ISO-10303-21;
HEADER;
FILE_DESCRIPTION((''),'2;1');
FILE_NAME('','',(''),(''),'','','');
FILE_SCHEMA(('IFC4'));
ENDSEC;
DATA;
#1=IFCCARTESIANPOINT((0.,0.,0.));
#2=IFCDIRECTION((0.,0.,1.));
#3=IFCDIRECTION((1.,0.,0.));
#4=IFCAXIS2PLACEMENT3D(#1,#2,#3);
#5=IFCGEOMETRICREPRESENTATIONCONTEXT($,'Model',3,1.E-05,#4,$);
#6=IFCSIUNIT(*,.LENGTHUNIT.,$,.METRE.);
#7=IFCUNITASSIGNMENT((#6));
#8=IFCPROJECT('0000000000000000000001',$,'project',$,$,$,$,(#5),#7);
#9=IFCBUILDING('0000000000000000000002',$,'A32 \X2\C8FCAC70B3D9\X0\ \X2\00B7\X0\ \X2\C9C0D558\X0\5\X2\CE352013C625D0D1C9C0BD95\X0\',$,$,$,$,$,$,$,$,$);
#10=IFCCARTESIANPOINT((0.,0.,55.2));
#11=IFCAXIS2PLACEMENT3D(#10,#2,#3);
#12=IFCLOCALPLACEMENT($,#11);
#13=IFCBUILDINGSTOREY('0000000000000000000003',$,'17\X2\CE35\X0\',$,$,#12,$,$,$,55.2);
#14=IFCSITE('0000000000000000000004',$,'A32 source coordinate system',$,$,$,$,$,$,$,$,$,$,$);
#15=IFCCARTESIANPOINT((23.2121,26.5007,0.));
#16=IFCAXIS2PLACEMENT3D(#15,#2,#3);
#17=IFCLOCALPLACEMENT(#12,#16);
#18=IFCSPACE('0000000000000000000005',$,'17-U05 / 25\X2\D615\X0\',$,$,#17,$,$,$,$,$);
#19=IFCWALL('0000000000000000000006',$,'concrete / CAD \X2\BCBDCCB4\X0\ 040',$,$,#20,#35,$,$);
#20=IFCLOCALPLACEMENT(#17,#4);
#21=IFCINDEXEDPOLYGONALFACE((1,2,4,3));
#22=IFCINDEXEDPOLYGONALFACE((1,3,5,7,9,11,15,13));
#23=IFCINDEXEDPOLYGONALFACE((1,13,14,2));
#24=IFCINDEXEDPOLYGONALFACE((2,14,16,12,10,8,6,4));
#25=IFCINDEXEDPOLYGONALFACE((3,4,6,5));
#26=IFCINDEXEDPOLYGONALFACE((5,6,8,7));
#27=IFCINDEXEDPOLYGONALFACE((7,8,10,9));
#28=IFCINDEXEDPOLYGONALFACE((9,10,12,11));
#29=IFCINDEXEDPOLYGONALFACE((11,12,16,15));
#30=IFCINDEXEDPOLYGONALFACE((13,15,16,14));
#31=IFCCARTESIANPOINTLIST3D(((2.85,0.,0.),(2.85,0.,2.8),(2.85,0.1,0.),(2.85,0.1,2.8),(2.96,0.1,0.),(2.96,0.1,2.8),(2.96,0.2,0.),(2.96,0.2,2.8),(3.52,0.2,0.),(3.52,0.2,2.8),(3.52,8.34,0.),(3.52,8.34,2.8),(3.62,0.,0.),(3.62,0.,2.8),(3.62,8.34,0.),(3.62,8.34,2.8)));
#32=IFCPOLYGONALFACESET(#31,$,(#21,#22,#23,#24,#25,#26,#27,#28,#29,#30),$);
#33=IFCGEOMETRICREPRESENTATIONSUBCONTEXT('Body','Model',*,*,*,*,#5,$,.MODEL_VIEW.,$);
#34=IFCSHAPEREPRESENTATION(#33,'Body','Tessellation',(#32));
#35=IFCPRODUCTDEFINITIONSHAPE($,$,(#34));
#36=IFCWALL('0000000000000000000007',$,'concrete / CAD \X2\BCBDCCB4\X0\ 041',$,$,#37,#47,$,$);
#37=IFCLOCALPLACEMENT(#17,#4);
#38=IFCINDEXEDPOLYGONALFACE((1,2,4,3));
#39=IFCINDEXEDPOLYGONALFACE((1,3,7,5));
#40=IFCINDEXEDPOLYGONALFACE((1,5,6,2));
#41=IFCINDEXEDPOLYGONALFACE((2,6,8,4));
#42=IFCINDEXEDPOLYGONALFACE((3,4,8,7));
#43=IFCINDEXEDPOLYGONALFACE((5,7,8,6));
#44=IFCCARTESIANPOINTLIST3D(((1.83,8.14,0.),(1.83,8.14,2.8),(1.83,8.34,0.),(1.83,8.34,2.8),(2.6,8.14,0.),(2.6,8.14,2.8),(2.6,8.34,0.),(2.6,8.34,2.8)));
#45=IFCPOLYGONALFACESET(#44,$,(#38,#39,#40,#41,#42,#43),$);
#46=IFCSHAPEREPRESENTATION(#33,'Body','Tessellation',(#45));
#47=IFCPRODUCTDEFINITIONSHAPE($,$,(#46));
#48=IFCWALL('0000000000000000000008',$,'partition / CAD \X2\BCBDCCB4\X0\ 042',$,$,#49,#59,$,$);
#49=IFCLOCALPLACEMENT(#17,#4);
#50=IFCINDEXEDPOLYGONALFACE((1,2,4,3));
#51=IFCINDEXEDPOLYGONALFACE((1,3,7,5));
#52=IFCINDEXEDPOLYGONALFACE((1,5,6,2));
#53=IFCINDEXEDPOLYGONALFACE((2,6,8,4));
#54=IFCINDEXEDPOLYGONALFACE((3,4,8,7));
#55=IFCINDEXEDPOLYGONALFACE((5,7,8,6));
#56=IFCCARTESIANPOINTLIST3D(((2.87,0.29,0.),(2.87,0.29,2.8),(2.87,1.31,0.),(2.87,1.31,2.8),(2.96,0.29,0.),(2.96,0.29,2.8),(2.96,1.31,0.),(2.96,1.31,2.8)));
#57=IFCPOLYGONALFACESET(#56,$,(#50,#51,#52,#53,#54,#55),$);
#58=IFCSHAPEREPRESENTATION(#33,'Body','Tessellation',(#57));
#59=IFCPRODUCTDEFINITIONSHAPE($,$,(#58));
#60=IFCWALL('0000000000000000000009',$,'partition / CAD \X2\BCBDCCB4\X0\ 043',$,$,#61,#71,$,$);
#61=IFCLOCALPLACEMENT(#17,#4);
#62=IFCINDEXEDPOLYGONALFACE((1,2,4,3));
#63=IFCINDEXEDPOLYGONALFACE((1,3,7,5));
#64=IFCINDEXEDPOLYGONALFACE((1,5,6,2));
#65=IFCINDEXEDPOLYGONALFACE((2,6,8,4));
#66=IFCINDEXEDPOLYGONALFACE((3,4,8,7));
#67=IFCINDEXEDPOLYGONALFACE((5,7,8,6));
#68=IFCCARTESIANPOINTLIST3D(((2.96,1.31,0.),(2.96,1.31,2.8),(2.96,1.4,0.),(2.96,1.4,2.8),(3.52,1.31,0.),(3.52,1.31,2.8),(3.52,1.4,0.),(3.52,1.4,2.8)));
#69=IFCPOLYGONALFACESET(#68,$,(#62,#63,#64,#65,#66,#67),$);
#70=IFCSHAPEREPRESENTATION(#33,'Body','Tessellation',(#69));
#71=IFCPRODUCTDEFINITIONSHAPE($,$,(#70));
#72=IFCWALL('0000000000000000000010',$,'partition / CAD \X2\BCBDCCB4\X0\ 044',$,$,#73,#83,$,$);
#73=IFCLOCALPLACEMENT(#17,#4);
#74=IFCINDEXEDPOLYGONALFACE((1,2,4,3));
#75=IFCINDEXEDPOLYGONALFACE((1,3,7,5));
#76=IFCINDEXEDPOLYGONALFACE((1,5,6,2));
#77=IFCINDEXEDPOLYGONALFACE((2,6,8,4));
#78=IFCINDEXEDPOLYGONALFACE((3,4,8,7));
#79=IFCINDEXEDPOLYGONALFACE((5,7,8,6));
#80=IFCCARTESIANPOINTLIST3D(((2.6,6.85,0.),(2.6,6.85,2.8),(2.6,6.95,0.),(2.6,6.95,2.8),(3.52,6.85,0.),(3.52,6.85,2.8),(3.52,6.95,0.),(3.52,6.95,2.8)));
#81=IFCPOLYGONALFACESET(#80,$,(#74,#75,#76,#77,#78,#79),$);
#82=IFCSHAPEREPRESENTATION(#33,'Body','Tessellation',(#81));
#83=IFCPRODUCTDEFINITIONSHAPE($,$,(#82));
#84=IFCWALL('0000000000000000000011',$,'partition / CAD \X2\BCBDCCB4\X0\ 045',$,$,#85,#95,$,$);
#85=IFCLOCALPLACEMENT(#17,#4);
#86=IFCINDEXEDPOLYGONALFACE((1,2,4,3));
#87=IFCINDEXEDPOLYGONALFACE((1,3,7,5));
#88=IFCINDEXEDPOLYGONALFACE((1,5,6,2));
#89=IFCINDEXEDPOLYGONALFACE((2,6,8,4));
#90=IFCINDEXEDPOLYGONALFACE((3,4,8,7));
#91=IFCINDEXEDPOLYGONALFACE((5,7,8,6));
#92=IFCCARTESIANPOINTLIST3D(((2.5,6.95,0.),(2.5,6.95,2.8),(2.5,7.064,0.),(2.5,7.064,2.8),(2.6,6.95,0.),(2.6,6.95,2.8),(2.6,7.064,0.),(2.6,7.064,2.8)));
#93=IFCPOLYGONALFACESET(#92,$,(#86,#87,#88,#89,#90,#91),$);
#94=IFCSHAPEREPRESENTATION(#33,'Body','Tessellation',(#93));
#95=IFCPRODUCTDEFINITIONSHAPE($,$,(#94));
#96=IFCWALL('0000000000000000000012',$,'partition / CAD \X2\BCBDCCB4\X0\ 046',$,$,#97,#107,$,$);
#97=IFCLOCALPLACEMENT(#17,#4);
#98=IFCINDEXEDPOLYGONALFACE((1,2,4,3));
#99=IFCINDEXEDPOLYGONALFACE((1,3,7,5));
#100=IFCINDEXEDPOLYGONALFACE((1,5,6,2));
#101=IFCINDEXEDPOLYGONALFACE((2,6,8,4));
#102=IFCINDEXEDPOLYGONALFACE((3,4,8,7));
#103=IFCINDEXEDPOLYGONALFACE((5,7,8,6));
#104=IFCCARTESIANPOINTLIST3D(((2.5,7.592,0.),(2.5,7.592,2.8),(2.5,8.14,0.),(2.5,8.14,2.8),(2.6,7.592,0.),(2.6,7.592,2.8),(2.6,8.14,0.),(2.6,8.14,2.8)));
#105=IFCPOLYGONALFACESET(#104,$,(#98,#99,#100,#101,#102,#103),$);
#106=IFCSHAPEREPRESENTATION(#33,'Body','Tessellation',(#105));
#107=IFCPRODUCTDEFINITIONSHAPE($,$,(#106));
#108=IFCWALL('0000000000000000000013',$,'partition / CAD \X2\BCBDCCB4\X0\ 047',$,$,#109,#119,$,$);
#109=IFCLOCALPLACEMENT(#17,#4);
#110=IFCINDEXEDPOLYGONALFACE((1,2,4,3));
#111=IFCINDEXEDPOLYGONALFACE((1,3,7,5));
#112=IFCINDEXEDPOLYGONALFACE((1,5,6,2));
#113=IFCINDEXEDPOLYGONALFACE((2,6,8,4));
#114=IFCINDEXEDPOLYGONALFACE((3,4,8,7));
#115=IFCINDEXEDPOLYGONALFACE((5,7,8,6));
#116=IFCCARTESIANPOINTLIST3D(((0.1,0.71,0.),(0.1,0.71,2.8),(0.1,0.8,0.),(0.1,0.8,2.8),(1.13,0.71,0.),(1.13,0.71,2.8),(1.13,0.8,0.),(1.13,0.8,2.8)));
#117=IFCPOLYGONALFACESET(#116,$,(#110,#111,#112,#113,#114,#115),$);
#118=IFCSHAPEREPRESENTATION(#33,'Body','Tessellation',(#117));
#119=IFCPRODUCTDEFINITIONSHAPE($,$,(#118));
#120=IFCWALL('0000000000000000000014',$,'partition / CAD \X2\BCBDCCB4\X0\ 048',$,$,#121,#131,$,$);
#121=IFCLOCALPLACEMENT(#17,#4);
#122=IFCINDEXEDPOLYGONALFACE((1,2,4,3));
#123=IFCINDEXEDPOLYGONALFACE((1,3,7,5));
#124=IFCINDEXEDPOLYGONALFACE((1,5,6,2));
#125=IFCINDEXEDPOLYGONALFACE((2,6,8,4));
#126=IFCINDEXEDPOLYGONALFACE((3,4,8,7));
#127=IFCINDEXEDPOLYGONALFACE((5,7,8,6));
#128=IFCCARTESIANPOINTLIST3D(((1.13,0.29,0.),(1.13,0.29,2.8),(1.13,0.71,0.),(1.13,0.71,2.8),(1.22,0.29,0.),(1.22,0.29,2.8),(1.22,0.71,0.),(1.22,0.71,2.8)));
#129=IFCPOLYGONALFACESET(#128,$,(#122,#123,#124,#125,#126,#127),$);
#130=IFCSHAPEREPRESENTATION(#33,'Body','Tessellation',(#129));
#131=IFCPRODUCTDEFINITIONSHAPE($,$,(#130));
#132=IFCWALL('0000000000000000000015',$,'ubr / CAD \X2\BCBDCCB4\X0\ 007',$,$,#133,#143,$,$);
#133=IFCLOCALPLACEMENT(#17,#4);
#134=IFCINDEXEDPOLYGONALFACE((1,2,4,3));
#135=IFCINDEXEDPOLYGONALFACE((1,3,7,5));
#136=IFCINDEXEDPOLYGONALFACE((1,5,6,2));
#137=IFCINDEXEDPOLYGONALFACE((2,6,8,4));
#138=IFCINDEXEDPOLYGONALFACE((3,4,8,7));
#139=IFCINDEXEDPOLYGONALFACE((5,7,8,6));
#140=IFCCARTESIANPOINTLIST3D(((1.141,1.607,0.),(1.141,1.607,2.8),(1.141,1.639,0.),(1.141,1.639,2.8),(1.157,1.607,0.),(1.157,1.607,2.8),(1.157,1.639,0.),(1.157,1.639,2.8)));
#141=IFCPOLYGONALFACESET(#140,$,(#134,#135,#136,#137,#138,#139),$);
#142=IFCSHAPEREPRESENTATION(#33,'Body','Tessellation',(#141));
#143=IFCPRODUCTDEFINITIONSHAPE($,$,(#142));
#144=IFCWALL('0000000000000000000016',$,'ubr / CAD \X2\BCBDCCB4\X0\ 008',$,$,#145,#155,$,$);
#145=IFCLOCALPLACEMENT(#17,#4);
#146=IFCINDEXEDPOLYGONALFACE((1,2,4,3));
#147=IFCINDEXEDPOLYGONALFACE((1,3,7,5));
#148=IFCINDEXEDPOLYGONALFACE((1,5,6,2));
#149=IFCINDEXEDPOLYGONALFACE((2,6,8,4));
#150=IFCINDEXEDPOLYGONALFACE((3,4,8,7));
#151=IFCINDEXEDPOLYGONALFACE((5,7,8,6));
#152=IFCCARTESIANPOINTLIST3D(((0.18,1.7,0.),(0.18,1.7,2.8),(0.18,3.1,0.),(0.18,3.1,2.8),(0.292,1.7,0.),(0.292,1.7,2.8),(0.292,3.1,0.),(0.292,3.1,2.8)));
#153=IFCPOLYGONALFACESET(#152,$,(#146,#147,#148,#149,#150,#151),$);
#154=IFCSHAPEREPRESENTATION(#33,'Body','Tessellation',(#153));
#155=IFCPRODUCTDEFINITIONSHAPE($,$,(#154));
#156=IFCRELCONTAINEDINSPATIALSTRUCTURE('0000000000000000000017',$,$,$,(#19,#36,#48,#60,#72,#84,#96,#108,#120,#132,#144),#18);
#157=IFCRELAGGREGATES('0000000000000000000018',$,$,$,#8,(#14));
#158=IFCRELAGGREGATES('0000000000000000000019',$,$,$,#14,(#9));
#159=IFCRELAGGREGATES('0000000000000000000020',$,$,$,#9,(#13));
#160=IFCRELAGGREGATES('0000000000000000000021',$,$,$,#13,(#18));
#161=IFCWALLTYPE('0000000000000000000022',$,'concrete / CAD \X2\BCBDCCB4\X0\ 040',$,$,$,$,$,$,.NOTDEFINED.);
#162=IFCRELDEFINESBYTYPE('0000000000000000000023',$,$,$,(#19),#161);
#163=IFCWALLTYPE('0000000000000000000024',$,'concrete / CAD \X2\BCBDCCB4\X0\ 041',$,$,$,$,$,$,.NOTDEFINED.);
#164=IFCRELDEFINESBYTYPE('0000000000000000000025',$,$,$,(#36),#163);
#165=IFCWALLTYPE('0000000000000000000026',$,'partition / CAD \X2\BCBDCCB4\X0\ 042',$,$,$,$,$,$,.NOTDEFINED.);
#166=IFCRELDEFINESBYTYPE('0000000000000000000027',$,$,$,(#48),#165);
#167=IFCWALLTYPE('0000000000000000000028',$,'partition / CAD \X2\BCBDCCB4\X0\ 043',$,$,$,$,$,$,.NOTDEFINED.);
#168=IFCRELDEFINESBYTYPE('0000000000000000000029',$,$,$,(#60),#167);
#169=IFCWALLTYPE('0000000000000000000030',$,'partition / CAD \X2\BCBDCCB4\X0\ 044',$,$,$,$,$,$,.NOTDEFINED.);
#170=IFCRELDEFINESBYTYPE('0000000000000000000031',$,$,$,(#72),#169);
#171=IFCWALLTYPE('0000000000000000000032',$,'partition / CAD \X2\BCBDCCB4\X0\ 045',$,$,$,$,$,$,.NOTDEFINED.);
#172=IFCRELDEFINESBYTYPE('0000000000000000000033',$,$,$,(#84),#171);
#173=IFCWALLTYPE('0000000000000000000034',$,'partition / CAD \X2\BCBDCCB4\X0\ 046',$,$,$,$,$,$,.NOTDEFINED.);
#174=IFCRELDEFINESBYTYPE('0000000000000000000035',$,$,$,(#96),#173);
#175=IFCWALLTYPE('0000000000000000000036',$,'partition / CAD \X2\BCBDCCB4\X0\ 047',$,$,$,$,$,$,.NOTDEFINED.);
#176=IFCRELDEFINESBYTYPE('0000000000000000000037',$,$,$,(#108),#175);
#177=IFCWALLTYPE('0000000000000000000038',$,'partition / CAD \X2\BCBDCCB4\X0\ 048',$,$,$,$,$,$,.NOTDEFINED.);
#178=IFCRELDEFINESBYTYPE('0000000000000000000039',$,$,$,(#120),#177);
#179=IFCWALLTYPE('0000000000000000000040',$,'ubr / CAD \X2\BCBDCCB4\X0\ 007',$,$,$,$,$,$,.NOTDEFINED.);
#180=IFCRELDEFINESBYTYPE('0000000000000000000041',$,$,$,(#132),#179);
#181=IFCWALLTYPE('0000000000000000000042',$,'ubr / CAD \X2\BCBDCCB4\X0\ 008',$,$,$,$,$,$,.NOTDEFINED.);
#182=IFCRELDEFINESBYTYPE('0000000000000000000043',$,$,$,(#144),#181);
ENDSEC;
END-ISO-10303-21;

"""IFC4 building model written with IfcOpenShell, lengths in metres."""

from ifc_helpers import new_model, si_unit, frame, origin, origin_with_axes, place, context, subcontext, project, spatial, polyline, outline, extrude, source, transform, mapped, type_object, type_shapes, element, save


model = new_model("IFC4")

# Units and contexts
model_context = context("Model", 3, precision=1e-05, world=origin_with_axes())
body_context = subcontext(model_context, "Body", "Model", "MODEL_VIEW")
ifc_project = project(units=[si_unit("LENGTHUNIT", "METRE")], contexts=[model_context])

# Site, building, storey, space
site = spatial("IfcSite", under=ifc_project, Name="A32 source coordinate system")
building = spatial("IfcBuilding", under=site, Name="A32 주거동 · 지하5층–옥탑지붕")
storey_placement = place(None, frame((0.0, 0.0, 55.2), z_axis=(0.0, 0.0, 1.0), x_axis=(1.0, 0.0, 0.0)))
storey = spatial("IfcBuildingStorey", under=building, at=storey_placement, Name="17층", Elevation=55.2)
space_1_placement = place(storey_placement, frame((23.2121, 26.5007, 0.0), z_axis=(0.0, 0.0, 1.0), x_axis=(1.0, 0.0, 0.0)))
space_1 = spatial("IfcSpace", under=storey, at=space_1_placement, Name="17-U05 / 25형")

# Walls
wall_type_1 = type_object("IfcWallType", Name="concrete / CAD 벽체 040", PredefinedType="NOTDEFINED")
shared_shape_1 = source(origin(), body_context, "Body", "SweptSolid", [
    extrude(outline(polyline([(3.62, 8.34), (3.62, 0.0), (2.85, 0.0), (2.85, 0.1), (2.96, 0.1), (2.96, 0.2), (3.52, 0.2), (3.52, 8.34), (3.62, 8.34)])), origin(), (0.0, 0.0, 1.0), 2.8),
])
type_shapes(wall_type_1, [shared_shape_1])
wall_1_placement = place(space_1_placement, origin_with_axes())
element("IfcWall", 1, at=wall_1_placement, inside=space_1, type_object=wall_type_1, Name="concrete / CAD 벽체 040", context=body_context, shape_type="MappedRepresentation", body=[
    mapped(shared_shape_1, transform((0.0, 0.0, 0.0), scale=1.0)),
])
wall_type_2 = type_object("IfcWallType", Name="concrete / CAD 벽체 041", PredefinedType="NOTDEFINED")
shared_shape_2 = source(origin(), body_context, "Body", "SweptSolid", [
    extrude(outline(polyline([(2.6, 8.14), (1.83, 8.14), (1.83, 8.34), (2.6, 8.34), (2.6, 8.14)])), origin(), (0.0, 0.0, 1.0), 2.8),
])
type_shapes(wall_type_2, [shared_shape_2])
wall_2_placement = place(space_1_placement, origin_with_axes())
element("IfcWall", 2, at=wall_2_placement, inside=space_1, type_object=wall_type_2, Name="concrete / CAD 벽체 041", context=body_context, shape_type="MappedRepresentation", body=[
    mapped(shared_shape_2, transform((0.0, 0.0, 0.0), scale=1.0)),
])
wall_type_3 = type_object("IfcWallType", Name="partition / CAD 벽체 042", PredefinedType="NOTDEFINED")
shared_shape_3 = source(origin(), body_context, "Body", "SweptSolid", [
    extrude(outline(polyline([(2.87, 1.31), (2.96, 1.31), (2.96, 0.29), (2.87, 0.29), (2.87, 1.31)])), origin(), (0.0, 0.0, 1.0), 2.8),
])
type_shapes(wall_type_3, [shared_shape_3])
wall_3_placement = place(space_1_placement, origin_with_axes())
element("IfcWall", 3, at=wall_3_placement, inside=space_1, type_object=wall_type_3, Name="partition / CAD 벽체 042", context=body_context, shape_type="MappedRepresentation", body=[
    mapped(shared_shape_3, transform((0.0, 0.0, 0.0), scale=1.0)),
])
wall_type_4 = type_object("IfcWallType", Name="partition / CAD 벽체 043", PredefinedType="NOTDEFINED")
shared_shape_4 = source(origin(), body_context, "Body", "SweptSolid", [
    extrude(outline(polyline([(3.52, 1.4), (3.52, 1.31), (2.96, 1.31), (2.96, 1.4), (3.52, 1.4)])), origin(), (0.0, 0.0, 1.0), 2.8),
])
type_shapes(wall_type_4, [shared_shape_4])
wall_4_placement = place(space_1_placement, origin_with_axes())
element("IfcWall", 4, at=wall_4_placement, inside=space_1, type_object=wall_type_4, Name="partition / CAD 벽체 043", context=body_context, shape_type="MappedRepresentation", body=[
    mapped(shared_shape_4, transform((0.0, 0.0, 0.0), scale=1.0)),
])
wall_type_5 = type_object("IfcWallType", Name="partition / CAD 벽체 044", PredefinedType="NOTDEFINED")
shared_shape_5 = source(origin(), body_context, "Body", "SweptSolid", [
    extrude(outline(polyline([(3.52, 6.95), (3.52, 6.85), (2.6, 6.85), (2.6, 6.95), (3.52, 6.95)])), origin(), (0.0, 0.0, 1.0), 2.8),
])
type_shapes(wall_type_5, [shared_shape_5])
wall_5_placement = place(space_1_placement, origin_with_axes())
element("IfcWall", 5, at=wall_5_placement, inside=space_1, type_object=wall_type_5, Name="partition / CAD 벽체 044", context=body_context, shape_type="MappedRepresentation", body=[
    mapped(shared_shape_5, transform((0.0, 0.0, 0.0), scale=1.0)),
])
wall_type_6 = type_object("IfcWallType", Name="partition / CAD 벽체 045", PredefinedType="NOTDEFINED")
shared_shape_6 = source(origin(), body_context, "Body", "SweptSolid", [
    extrude(outline(polyline([(2.5, 7.064), (2.6, 7.064), (2.6, 6.95), (2.5, 6.95), (2.5, 7.064)])), origin(), (0.0, 0.0, 1.0), 2.8),
])
type_shapes(wall_type_6, [shared_shape_6])
wall_6_placement = place(space_1_placement, origin_with_axes())
element("IfcWall", 6, at=wall_6_placement, inside=space_1, type_object=wall_type_6, Name="partition / CAD 벽체 045", context=body_context, shape_type="MappedRepresentation", body=[
    mapped(shared_shape_6, transform((0.0, 0.0, 0.0), scale=1.0)),
])
wall_type_7 = type_object("IfcWallType", Name="partition / CAD 벽체 046", PredefinedType="NOTDEFINED")
shared_shape_7 = source(origin(), body_context, "Body", "SweptSolid", [
    extrude(outline(polyline([(2.6, 7.592), (2.5, 7.592), (2.5, 8.14), (2.6, 8.14), (2.6, 7.592)])), origin(), (0.0, 0.0, 1.0), 2.8),
])
type_shapes(wall_type_7, [shared_shape_7])
wall_7_placement = place(space_1_placement, origin_with_axes())
element("IfcWall", 7, at=wall_7_placement, inside=space_1, type_object=wall_type_7, Name="partition / CAD 벽체 046", context=body_context, shape_type="MappedRepresentation", body=[
    mapped(shared_shape_7, transform((0.0, 0.0, 0.0), scale=1.0)),
])
wall_type_8 = type_object("IfcWallType", Name="partition / CAD 벽체 047", PredefinedType="NOTDEFINED")
shared_shape_8 = source(origin(), body_context, "Body", "SweptSolid", [
    extrude(outline(polyline([(1.13, 0.71), (0.1, 0.71), (0.1, 0.8), (1.13, 0.8), (1.13, 0.71)])), origin(), (0.0, 0.0, 1.0), 2.8),
])
type_shapes(wall_type_8, [shared_shape_8])
wall_8_placement = place(space_1_placement, origin_with_axes())
element("IfcWall", 8, at=wall_8_placement, inside=space_1, type_object=wall_type_8, Name="partition / CAD 벽체 047", context=body_context, shape_type="MappedRepresentation", body=[
    mapped(shared_shape_8, transform((0.0, 0.0, 0.0), scale=1.0)),
])
wall_type_9 = type_object("IfcWallType", Name="partition / CAD 벽체 048", PredefinedType="NOTDEFINED")
shared_shape_9 = source(origin(), body_context, "Body", "SweptSolid", [
    extrude(outline(polyline([(1.22, 0.29), (1.13, 0.29), (1.13, 0.71), (1.22, 0.71), (1.22, 0.29)])), origin(), (0.0, 0.0, 1.0), 2.8),
])
type_shapes(wall_type_9, [shared_shape_9])
wall_9_placement = place(space_1_placement, origin_with_axes())
element("IfcWall", 9, at=wall_9_placement, inside=space_1, type_object=wall_type_9, Name="partition / CAD 벽체 048", context=body_context, shape_type="MappedRepresentation", body=[
    mapped(shared_shape_9, transform((0.0, 0.0, 0.0), scale=1.0)),
])
wall_type_10 = type_object("IfcWallType", Name="ubr / CAD 벽체 007", PredefinedType="NOTDEFINED")
shared_shape_10 = source(origin(), body_context, "Body", "SweptSolid", [
    extrude(outline(polyline([(1.157, 1.607), (1.141, 1.607), (1.141, 1.639), (1.157, 1.639), (1.157, 1.607)])), origin(), (0.0, 0.0, 1.0), 2.8),
])
type_shapes(wall_type_10, [shared_shape_10])
wall_10_placement = place(space_1_placement, origin_with_axes())
element("IfcWall", 10, at=wall_10_placement, inside=space_1, type_object=wall_type_10, Name="ubr / CAD 벽체 007", context=body_context, shape_type="MappedRepresentation", body=[
    mapped(shared_shape_10, transform((0.0, 0.0, 0.0), scale=1.0)),
])
wall_type_11 = type_object("IfcWallType", Name="ubr / CAD 벽체 008", PredefinedType="NOTDEFINED")
shared_shape_11 = source(origin(), body_context, "Body", "SweptSolid", [
    extrude(outline(polyline([(0.292, 1.7), (0.18, 1.7), (0.18, 3.1), (0.292, 3.1), (0.292, 1.7)])), origin(), (0.0, 0.0, 1.0), 2.8),
])
type_shapes(wall_type_11, [shared_shape_11])
wall_11_placement = place(space_1_placement, origin_with_axes())
element("IfcWall", 11, at=wall_11_placement, inside=space_1, type_object=wall_type_11, Name="ubr / CAD 벽체 008", context=body_context, shape_type="MappedRepresentation", body=[
    mapped(shared_shape_11, transform((0.0, 0.0, 0.0), scale=1.0)),
])

save(model, "model.ifc")
